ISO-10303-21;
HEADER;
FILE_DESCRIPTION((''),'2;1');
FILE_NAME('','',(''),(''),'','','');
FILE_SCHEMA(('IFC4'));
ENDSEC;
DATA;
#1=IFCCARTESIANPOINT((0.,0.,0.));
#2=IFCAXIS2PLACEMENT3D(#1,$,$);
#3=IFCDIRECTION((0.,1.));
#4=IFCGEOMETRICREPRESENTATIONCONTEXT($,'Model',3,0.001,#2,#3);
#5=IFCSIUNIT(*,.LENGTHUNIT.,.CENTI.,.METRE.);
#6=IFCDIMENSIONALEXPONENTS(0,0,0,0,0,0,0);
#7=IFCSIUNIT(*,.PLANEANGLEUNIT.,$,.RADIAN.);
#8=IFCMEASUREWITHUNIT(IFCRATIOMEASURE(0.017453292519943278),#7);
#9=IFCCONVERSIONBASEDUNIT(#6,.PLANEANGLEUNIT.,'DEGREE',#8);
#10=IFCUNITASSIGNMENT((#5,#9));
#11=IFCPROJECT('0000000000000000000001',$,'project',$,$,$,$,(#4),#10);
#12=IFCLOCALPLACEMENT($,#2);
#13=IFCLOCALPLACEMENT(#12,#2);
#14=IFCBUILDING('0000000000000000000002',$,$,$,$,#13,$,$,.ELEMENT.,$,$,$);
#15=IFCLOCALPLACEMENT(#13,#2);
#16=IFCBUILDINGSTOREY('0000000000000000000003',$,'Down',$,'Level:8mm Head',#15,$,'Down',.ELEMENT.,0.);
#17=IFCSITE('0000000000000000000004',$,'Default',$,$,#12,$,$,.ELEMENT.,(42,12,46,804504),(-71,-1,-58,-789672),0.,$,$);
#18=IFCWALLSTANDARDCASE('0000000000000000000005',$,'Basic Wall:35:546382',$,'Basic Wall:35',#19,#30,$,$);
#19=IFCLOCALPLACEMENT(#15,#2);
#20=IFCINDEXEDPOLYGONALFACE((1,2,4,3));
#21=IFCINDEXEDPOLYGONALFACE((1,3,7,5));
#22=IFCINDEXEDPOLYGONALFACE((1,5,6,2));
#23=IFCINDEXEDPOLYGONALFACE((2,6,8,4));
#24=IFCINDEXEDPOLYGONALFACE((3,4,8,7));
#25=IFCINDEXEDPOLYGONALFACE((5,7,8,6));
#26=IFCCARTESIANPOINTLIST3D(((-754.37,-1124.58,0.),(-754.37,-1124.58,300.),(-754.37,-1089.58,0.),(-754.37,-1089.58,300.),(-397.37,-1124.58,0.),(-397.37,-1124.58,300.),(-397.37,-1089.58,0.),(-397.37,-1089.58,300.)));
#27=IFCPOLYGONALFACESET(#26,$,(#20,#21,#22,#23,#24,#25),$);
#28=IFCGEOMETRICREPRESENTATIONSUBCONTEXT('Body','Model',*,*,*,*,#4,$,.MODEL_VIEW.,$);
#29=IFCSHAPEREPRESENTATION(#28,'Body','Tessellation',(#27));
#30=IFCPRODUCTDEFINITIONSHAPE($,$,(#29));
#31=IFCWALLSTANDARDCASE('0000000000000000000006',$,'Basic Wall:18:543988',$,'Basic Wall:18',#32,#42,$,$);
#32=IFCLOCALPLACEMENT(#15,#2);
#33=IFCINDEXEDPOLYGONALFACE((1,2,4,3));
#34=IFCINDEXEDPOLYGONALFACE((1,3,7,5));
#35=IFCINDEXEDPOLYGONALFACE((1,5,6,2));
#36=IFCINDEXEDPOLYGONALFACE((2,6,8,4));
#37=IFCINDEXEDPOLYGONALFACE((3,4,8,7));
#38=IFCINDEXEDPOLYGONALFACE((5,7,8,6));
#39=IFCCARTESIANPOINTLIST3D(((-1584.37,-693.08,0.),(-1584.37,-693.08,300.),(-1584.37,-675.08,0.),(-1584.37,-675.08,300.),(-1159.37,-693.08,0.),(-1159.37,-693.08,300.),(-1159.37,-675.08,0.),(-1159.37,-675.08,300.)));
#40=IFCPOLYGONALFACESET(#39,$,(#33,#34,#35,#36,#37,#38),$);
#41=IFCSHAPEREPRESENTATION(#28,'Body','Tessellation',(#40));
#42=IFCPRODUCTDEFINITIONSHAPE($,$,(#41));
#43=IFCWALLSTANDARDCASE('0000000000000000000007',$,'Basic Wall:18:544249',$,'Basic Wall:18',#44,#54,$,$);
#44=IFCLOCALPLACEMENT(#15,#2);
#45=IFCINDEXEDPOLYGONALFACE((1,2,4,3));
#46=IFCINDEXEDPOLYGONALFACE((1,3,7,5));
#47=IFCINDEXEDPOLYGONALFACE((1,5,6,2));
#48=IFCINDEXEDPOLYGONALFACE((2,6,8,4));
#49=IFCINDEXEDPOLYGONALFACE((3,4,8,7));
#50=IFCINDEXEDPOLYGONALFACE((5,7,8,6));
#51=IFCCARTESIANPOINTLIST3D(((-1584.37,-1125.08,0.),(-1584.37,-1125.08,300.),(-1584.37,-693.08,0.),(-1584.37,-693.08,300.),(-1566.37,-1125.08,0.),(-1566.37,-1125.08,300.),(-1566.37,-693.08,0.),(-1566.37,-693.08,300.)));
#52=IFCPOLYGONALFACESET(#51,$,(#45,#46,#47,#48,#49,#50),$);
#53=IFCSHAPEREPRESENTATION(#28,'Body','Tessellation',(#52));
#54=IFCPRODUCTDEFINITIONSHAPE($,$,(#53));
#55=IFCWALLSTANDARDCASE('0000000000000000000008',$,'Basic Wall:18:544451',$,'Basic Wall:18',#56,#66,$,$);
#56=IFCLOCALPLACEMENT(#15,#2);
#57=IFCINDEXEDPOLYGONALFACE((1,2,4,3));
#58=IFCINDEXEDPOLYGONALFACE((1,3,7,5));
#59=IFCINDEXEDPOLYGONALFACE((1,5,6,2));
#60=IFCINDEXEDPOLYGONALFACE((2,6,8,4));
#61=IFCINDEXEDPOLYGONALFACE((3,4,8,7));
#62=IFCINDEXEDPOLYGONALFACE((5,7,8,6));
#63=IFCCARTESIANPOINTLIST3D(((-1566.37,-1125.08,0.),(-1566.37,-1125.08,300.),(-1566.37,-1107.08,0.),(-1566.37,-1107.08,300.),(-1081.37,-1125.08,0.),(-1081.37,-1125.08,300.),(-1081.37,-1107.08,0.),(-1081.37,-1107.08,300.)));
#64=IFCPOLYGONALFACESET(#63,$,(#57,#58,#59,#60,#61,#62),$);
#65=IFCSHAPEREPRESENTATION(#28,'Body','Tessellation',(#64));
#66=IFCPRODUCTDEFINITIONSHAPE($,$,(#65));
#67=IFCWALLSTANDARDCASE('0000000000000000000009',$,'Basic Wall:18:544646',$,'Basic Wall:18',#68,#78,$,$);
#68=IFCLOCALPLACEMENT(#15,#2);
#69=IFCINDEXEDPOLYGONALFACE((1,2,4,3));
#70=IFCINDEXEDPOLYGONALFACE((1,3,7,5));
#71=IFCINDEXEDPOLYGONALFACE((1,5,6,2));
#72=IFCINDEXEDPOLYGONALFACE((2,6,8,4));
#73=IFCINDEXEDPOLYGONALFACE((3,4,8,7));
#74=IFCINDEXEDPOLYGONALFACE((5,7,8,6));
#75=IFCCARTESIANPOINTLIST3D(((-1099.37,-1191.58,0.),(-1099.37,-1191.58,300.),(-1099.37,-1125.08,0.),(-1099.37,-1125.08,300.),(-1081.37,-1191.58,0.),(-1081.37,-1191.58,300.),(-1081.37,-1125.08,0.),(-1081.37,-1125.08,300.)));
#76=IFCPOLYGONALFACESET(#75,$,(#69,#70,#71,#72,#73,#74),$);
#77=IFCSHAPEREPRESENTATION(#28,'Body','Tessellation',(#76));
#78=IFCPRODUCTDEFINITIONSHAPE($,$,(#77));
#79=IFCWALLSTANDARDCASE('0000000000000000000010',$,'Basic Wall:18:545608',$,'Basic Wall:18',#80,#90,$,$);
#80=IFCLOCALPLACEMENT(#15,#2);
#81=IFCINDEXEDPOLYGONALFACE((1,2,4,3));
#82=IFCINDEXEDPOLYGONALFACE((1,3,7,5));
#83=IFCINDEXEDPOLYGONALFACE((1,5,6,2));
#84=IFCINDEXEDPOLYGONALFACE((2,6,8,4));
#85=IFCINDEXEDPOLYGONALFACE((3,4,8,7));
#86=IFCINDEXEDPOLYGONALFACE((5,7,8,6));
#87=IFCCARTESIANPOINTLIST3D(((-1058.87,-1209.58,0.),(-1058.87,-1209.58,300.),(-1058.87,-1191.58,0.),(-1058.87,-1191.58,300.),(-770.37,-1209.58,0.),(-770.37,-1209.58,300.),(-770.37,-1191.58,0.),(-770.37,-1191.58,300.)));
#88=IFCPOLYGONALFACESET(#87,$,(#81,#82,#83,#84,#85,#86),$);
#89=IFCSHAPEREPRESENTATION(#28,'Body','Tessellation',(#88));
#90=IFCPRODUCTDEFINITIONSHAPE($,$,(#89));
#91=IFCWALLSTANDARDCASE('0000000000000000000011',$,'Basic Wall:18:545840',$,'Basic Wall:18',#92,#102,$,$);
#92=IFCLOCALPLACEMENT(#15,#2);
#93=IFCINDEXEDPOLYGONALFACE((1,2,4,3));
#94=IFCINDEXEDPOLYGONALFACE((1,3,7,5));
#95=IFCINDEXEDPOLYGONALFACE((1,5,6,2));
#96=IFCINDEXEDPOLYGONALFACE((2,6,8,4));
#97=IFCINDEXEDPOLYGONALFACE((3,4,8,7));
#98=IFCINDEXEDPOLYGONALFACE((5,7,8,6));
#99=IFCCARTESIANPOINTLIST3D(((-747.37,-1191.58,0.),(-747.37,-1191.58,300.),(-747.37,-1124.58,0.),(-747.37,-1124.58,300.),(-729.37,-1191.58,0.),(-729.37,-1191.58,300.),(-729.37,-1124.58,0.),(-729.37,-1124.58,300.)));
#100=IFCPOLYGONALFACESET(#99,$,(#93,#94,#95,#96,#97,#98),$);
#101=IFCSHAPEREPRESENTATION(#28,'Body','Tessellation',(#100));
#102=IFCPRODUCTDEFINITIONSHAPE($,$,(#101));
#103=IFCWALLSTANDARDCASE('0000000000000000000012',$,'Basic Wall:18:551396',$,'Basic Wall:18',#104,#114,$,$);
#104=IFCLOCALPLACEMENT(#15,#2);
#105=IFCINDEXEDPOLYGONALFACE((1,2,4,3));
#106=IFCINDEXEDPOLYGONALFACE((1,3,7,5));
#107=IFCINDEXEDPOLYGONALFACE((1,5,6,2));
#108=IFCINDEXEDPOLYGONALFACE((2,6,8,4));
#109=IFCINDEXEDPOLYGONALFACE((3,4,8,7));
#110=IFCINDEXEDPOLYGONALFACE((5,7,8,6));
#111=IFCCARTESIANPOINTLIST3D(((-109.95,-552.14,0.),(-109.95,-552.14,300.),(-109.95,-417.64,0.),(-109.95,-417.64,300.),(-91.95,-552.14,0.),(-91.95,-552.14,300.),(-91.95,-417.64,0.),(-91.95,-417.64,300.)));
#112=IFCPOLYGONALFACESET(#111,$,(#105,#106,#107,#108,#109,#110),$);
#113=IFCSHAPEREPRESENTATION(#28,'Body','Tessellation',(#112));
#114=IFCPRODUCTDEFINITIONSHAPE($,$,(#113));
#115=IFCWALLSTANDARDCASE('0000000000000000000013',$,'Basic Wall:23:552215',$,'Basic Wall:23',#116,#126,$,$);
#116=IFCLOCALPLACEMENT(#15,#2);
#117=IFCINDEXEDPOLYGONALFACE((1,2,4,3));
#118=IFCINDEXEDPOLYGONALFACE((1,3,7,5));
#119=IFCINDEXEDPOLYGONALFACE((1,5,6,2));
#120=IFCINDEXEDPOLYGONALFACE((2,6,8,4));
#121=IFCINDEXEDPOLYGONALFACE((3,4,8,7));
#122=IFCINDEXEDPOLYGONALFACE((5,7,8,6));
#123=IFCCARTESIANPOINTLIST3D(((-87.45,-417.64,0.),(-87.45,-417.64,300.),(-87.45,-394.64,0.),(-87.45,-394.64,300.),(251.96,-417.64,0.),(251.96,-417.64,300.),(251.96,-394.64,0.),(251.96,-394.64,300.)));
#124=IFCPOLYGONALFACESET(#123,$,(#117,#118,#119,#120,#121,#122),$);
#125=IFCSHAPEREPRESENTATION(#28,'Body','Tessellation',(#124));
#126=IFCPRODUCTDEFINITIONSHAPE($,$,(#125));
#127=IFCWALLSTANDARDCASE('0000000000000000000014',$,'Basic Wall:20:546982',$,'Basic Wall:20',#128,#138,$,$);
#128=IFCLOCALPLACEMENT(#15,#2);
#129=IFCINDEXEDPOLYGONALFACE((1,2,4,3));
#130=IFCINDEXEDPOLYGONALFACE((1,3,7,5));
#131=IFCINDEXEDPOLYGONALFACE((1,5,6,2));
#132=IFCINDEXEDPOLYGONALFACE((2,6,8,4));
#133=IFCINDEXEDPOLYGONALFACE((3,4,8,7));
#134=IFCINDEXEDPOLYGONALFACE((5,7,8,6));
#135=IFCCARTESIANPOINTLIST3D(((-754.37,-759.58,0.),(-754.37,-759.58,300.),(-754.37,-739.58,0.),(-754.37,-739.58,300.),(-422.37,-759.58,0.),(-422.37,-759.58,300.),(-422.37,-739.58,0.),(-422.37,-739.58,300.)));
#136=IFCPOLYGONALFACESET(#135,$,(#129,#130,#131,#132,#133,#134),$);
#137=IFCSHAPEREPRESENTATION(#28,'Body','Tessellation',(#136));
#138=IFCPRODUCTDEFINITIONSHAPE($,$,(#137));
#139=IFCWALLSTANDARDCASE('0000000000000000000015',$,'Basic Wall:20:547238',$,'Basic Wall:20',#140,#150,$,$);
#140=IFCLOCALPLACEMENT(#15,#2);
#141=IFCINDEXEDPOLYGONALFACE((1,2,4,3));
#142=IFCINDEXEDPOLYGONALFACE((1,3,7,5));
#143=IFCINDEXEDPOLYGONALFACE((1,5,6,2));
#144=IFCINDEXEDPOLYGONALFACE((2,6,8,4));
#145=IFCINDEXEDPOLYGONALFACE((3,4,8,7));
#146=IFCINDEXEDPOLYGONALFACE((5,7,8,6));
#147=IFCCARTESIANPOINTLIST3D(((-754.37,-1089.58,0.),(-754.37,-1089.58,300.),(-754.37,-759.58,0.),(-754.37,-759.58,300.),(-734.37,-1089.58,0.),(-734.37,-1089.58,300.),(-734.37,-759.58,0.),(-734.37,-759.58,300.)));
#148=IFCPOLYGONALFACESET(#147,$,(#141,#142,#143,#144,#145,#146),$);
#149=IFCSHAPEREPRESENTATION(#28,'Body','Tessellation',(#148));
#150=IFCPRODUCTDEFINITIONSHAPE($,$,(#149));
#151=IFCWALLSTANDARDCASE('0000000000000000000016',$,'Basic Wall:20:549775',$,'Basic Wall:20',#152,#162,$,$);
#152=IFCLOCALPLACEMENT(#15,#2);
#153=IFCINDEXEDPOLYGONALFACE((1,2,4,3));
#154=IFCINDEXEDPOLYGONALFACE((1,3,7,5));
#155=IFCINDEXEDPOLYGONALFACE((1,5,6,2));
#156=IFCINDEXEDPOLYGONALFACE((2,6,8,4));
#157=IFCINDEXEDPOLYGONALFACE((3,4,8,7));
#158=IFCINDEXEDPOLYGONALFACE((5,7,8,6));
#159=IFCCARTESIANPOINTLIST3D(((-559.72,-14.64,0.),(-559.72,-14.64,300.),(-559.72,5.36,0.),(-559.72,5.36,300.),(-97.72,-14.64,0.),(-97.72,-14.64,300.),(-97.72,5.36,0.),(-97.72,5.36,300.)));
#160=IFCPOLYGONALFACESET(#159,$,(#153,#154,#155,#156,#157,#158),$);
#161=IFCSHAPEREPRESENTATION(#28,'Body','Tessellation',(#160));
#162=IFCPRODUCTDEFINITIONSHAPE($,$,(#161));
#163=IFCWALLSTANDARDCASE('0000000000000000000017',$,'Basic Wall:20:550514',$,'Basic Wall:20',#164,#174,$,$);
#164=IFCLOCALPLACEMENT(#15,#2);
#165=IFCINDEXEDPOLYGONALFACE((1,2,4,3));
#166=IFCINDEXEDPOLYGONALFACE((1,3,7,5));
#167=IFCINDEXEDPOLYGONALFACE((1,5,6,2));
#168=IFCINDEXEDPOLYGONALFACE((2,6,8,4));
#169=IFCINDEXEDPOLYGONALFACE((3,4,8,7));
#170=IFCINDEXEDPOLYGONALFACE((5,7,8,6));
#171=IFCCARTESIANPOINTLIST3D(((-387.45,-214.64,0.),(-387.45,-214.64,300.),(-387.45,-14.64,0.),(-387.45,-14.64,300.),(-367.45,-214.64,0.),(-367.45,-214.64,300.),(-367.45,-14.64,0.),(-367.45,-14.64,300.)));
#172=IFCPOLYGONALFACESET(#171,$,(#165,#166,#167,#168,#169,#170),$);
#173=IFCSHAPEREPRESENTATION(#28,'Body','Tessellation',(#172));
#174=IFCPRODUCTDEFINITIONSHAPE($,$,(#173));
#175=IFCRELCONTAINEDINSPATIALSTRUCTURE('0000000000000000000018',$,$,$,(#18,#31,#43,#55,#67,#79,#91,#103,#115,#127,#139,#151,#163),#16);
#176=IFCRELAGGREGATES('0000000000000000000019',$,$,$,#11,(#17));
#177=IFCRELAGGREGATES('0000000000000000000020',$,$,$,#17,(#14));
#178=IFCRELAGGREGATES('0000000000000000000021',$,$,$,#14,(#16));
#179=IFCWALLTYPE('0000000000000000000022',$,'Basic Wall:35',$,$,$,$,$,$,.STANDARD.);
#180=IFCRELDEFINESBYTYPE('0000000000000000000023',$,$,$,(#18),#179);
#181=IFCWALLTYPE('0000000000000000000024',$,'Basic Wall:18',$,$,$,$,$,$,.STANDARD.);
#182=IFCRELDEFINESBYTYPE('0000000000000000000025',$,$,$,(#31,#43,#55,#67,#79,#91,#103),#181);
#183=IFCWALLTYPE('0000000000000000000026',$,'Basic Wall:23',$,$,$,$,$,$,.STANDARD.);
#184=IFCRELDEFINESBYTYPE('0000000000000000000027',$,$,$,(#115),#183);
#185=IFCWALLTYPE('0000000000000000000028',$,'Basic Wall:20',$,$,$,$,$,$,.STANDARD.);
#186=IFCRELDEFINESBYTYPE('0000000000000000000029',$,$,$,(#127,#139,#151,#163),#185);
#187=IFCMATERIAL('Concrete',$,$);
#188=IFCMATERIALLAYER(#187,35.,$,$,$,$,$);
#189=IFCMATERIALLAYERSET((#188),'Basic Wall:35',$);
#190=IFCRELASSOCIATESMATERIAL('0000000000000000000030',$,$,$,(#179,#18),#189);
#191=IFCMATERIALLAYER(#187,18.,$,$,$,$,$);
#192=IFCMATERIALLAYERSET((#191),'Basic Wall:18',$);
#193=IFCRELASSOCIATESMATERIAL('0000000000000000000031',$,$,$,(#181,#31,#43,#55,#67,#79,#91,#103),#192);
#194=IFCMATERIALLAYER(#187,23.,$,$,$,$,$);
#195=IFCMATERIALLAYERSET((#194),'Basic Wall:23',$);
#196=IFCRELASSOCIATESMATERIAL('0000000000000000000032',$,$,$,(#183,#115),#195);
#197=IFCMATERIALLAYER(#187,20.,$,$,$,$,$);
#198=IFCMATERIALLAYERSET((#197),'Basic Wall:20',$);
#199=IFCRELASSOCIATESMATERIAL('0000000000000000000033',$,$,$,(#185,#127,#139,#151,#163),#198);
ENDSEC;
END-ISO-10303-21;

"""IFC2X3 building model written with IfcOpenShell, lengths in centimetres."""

from ifc_helpers import new_model, entity, si_unit, converted_unit, direction, frame, frame_2d, origin, place, context, subcontext, project, spatial, rectangle, extrude, material, layer, layer_set, layer_usage, type_object, element, save


model = new_model("IFC2X3")

# Units and contexts
model_context = context("Model", 3, precision=0.001, world=origin(), true_north=direction((0.0, 1.0)))
body_context = subcontext(model_context, "Body", "Model", "MODEL_VIEW")
ifc_project = project(units=[si_unit("LENGTHUNIT", "METRE", prefix="CENTI"), converted_unit("PLANEANGLEUNIT", "DEGREE", entity("IfcRatioMeasure", 0.017453292519943278), si_unit("PLANEANGLEUNIT", "RADIAN"), dimensions=[0, 0, 0, 0, 0, 0, 0])], contexts=[model_context])

# Site, building, storey
site_placement = place(None, origin())
site = spatial("IfcSite", under=ifc_project, at=site_placement, Name="Default", CompositionType="ELEMENT", RefLatitude=(42, 12, 46, 804504), RefLongitude=(-71, -1, -58, -789672), RefElevation=0.0)
building_placement = place(site_placement, origin())
building = spatial("IfcBuilding", under=site, at=building_placement, CompositionType="ELEMENT")
storey_placement = place(building_placement, origin())
storey = spatial("IfcBuildingStorey", under=building, at=storey_placement, Name="Down", ObjectType="Level:8mm Head", LongName="Down", CompositionType="ELEMENT", Elevation=0.0)

# Walls
ifc_material = material(Name="Concrete")
ifc_layer_1 = layer(ifc_material, 35.0)
ifc_layer_set_1 = layer_set([ifc_layer_1], Name="Basic Wall:35")
ifc_layer_usage_1 = layer_usage(ifc_layer_set_1, "AXIS2", "POSITIVE", -17.5)
wall_type_1 = type_object("IfcWallType", Name="Basic Wall:35", PredefinedType="STANDARD", material=ifc_layer_set_1)
wall_1_placement = place(storey_placement, frame((-754.37, -1107.08, 0.0)))
element("IfcWallStandardCase", 1, at=wall_1_placement, inside=storey, type_object=wall_type_1, material=ifc_layer_usage_1, Name="Basic Wall:35:546382", ObjectType="Basic Wall:35", context=body_context, shape_type="SweptSolid", body=[
    extrude(rectangle(XDim=357.0, YDim=35.0, at=frame_2d((178.5, 0.0), x_axis=(-1.0, 0.0))), origin(), (0.0, 0.0, 1.0), 300.0),
])
ifc_layer_2 = layer(ifc_material, 18.0)
ifc_layer_set_2 = layer_set([ifc_layer_2], Name="Basic Wall:18")
ifc_layer_usage_2 = layer_usage(ifc_layer_set_2, "AXIS2", "NEGATIVE", 9.0)
wall_type_2 = type_object("IfcWallType", Name="Basic Wall:18", PredefinedType="STANDARD", material=ifc_layer_set_2)
wall_2_placement = place(storey_placement, frame((-1159.37, -684.08, 0.0), z_axis=(0.0, 0.0, 1.0), x_axis=(-1.0, 0.0, 0.0)))
element("IfcWallStandardCase", 2, at=wall_2_placement, inside=storey, type_object=wall_type_2, material=ifc_layer_usage_2, Name="Basic Wall:18:543988", ObjectType="Basic Wall:18", context=body_context, shape_type="SweptSolid", body=[
    extrude(rectangle(XDim=425.0, YDim=18.0, at=frame_2d((212.5, 0.0), x_axis=(-1.0, 0.0))), origin(), (0.0, 0.0, 1.0), 300.0),
])
ifc_layer_usage_3 = layer_usage(ifc_layer_set_2, "AXIS2", "POSITIVE", -9.0)
wall_3_placement = place(storey_placement, frame((-1575.37, -693.08, 0.0), z_axis=(0.0, 0.0, 1.0), x_axis=(0.0, -1.0, 0.0)))
element("IfcWallStandardCase", 3, at=wall_3_placement, inside=storey, type_object=wall_type_2, material=ifc_layer_usage_3, Name="Basic Wall:18:544249", ObjectType="Basic Wall:18", context=body_context, shape_type="SweptSolid", body=[
    extrude(rectangle(XDim=432.0, YDim=18.0, at=frame_2d((216.0, 0.0), x_axis=(-1.0, 0.0))), origin(), (0.0, 0.0, 1.0), 300.0),
])
ifc_layer_usage_4 = layer_usage(ifc_layer_set_2, "AXIS2", "POSITIVE", -9.0)
wall_4_placement = place(storey_placement, frame((-1566.37, -1116.08, 0.0)))
element("IfcWallStandardCase", 4, at=wall_4_placement, inside=storey, type_object=wall_type_2, material=ifc_layer_usage_4, Name="Basic Wall:18:544451", ObjectType="Basic Wall:18", context=body_context, shape_type="SweptSolid", body=[
    extrude(rectangle(XDim=485.0, YDim=18.0, at=frame_2d((242.5, 0.0), x_axis=(-1.0, 0.0))), origin(), (0.0, 0.0, 1.0), 300.0),
])
ifc_layer_usage_5 = layer_usage(ifc_layer_set_2, "AXIS2", "NEGATIVE", 9.0)
wall_5_placement = place(storey_placement, frame((-1090.37, -1125.08, 0.0), z_axis=(0.0, 0.0, 1.0), x_axis=(0.0, -1.0, 0.0)))
element("IfcWallStandardCase", 5, at=wall_5_placement, inside=storey, type_object=wall_type_2, material=ifc_layer_usage_5, Name="Basic Wall:18:544646", ObjectType="Basic Wall:18", context=body_context, shape_type="SweptSolid", body=[
    extrude(rectangle(XDim=66.5, YDim=18.0, at=frame_2d((33.25, 0.0), x_axis=(-1.0, 0.0))), origin(), (0.0, 0.0, 1.0), 300.0),
])
ifc_layer_usage_6 = layer_usage(ifc_layer_set_2, "AXIS2", "NEGATIVE", 9.0)
wall_6_placement = place(storey_placement, frame((-1058.87, -1200.58, 0.0)))
element("IfcWallStandardCase", 6, at=wall_6_placement, inside=storey, type_object=wall_type_2, material=ifc_layer_usage_6, Name="Basic Wall:18:545608", ObjectType="Basic Wall:18", context=body_context, shape_type="SweptSolid", body=[
    extrude(rectangle(XDim=288.5, YDim=18.0, at=frame_2d((144.25, 0.0), x_axis=(-1.0, 0.0))), origin(), (0.0, 0.0, 1.0), 300.0),
])
ifc_layer_usage_7 = layer_usage(ifc_layer_set_2, "AXIS2", "NEGATIVE", 9.0)
wall_7_placement = place(storey_placement, frame((-738.37, -1191.58, 0.0), z_axis=(0.0, 0.0, 1.0), x_axis=(0.0, 1.0, 0.0)))
element("IfcWallStandardCase", 7, at=wall_7_placement, inside=storey, type_object=wall_type_2, material=ifc_layer_usage_7, Name="Basic Wall:18:545840", ObjectType="Basic Wall:18", context=body_context, shape_type="SweptSolid", body=[
    extrude(rectangle(XDim=67.0, YDim=18.0, at=frame_2d((33.5, 0.0), x_axis=(-1.0, 0.0))), origin(), (0.0, 0.0, 1.0), 300.0),
])
ifc_layer_usage_8 = layer_usage(ifc_layer_set_2, "AXIS2", "POSITIVE", -9.0)
wall_8_placement = place(storey_placement, frame((-100.95, -417.64, 0.0), z_axis=(0.0, 0.0, 1.0), x_axis=(0.0, -1.0, 0.0)))
element("IfcWallStandardCase", 8, at=wall_8_placement, inside=storey, type_object=wall_type_2, material=ifc_layer_usage_8, Name="Basic Wall:18:551396", ObjectType="Basic Wall:18", context=body_context, shape_type="SweptSolid", body=[
    extrude(rectangle(XDim=134.5, YDim=18.0, at=frame_2d((67.25, 0.0), x_axis=(-1.0, 0.0))), origin(), (0.0, 0.0, 1.0), 300.0),
])
ifc_layer_3 = layer(ifc_material, 23.0)
ifc_layer_set_3 = layer_set([ifc_layer_3], Name="Basic Wall:23")
ifc_layer_usage_9 = layer_usage(ifc_layer_set_3, "AXIS2", "POSITIVE", -11.5)
wall_type_3 = type_object("IfcWallType", Name="Basic Wall:23", PredefinedType="STANDARD", material=ifc_layer_set_3)
wall_9_placement = place(storey_placement, frame((-87.45, -406.14, 0.0)))
element("IfcWallStandardCase", 9, at=wall_9_placement, inside=storey, type_object=wall_type_3, material=ifc_layer_usage_9, Name="Basic Wall:23:552215", ObjectType="Basic Wall:23", context=body_context, shape_type="SweptSolid", body=[
    extrude(rectangle(XDim=339.41, YDim=23.0, at=frame_2d((169.7, 0.0), x_axis=(-1.0, 0.0))), origin(), (0.0, 0.0, 1.0), 300.0),
])
ifc_layer_4 = layer(ifc_material, 20.0)
ifc_layer_set_4 = layer_set([ifc_layer_4], Name="Basic Wall:20")
ifc_layer_usage_10 = layer_usage(ifc_layer_set_4, "AXIS2", "POSITIVE", -10.0)
wall_type_4 = type_object("IfcWallType", Name="Basic Wall:20", PredefinedType="STANDARD", material=ifc_layer_set_4)
wall_10_placement = place(storey_placement, frame((-422.37, -749.58, 0.0), z_axis=(0.0, 0.0, 1.0), x_axis=(-1.0, 0.0, 0.0)))
element("IfcWallStandardCase", 10, at=wall_10_placement, inside=storey, type_object=wall_type_4, material=ifc_layer_usage_10, Name="Basic Wall:20:546982", ObjectType="Basic Wall:20", context=body_context, shape_type="SweptSolid", body=[
    extrude(rectangle(XDim=332.0, YDim=20.0, at=frame_2d((166.0, 0.0), x_axis=(-1.0, 0.0))), origin(), (0.0, 0.0, 1.0), 300.0),
])
ifc_layer_usage_11 = layer_usage(ifc_layer_set_4, "AXIS2", "POSITIVE", -10.0)
wall_11_placement = place(storey_placement, frame((-744.37, -759.58, 0.0), z_axis=(0.0, 0.0, 1.0), x_axis=(0.0, -1.0, 0.0)))
element("IfcWallStandardCase", 11, at=wall_11_placement, inside=storey, type_object=wall_type_4, material=ifc_layer_usage_11, Name="Basic Wall:20:547238", ObjectType="Basic Wall:20", context=body_context, shape_type="SweptSolid", body=[
    extrude(rectangle(XDim=330.0, YDim=20.0, at=frame_2d((165.0, 0.0), x_axis=(-1.0, 0.0))), origin(), (0.0, 0.0, 1.0), 300.0),
])
ifc_layer_usage_12 = layer_usage(ifc_layer_set_4, "AXIS2", "POSITIVE", -10.0)
wall_12_placement = place(storey_placement, frame((-559.72, -4.64, 0.0)))
element("IfcWallStandardCase", 12, at=wall_12_placement, inside=storey, type_object=wall_type_4, material=ifc_layer_usage_12, Name="Basic Wall:20:549775", ObjectType="Basic Wall:20", context=body_context, shape_type="SweptSolid", body=[
    extrude(rectangle(XDim=462.0, YDim=20.0, at=frame_2d((231.0, 0.0), x_axis=(-1.0, 0.0))), origin(), (0.0, 0.0, 1.0), 300.0),
])
ifc_layer_usage_13 = layer_usage(ifc_layer_set_4, "AXIS2", "POSITIVE", -10.0)
wall_13_placement = place(storey_placement, frame((-377.45, -14.64, 0.0), z_axis=(0.0, 0.0, 1.0), x_axis=(0.0, -1.0, 0.0)))
element("IfcWallStandardCase", 13, at=wall_13_placement, inside=storey, type_object=wall_type_4, material=ifc_layer_usage_13, Name="Basic Wall:20:550514", ObjectType="Basic Wall:20", context=body_context, shape_type="SweptSolid", body=[
    extrude(rectangle(XDim=200.0, YDim=20.0, at=frame_2d((100.0, 0.0), x_axis=(-1.0, 0.0))), origin(), (0.0, 0.0, 1.0), 300.0),
])

save(model, "model.ifc")
